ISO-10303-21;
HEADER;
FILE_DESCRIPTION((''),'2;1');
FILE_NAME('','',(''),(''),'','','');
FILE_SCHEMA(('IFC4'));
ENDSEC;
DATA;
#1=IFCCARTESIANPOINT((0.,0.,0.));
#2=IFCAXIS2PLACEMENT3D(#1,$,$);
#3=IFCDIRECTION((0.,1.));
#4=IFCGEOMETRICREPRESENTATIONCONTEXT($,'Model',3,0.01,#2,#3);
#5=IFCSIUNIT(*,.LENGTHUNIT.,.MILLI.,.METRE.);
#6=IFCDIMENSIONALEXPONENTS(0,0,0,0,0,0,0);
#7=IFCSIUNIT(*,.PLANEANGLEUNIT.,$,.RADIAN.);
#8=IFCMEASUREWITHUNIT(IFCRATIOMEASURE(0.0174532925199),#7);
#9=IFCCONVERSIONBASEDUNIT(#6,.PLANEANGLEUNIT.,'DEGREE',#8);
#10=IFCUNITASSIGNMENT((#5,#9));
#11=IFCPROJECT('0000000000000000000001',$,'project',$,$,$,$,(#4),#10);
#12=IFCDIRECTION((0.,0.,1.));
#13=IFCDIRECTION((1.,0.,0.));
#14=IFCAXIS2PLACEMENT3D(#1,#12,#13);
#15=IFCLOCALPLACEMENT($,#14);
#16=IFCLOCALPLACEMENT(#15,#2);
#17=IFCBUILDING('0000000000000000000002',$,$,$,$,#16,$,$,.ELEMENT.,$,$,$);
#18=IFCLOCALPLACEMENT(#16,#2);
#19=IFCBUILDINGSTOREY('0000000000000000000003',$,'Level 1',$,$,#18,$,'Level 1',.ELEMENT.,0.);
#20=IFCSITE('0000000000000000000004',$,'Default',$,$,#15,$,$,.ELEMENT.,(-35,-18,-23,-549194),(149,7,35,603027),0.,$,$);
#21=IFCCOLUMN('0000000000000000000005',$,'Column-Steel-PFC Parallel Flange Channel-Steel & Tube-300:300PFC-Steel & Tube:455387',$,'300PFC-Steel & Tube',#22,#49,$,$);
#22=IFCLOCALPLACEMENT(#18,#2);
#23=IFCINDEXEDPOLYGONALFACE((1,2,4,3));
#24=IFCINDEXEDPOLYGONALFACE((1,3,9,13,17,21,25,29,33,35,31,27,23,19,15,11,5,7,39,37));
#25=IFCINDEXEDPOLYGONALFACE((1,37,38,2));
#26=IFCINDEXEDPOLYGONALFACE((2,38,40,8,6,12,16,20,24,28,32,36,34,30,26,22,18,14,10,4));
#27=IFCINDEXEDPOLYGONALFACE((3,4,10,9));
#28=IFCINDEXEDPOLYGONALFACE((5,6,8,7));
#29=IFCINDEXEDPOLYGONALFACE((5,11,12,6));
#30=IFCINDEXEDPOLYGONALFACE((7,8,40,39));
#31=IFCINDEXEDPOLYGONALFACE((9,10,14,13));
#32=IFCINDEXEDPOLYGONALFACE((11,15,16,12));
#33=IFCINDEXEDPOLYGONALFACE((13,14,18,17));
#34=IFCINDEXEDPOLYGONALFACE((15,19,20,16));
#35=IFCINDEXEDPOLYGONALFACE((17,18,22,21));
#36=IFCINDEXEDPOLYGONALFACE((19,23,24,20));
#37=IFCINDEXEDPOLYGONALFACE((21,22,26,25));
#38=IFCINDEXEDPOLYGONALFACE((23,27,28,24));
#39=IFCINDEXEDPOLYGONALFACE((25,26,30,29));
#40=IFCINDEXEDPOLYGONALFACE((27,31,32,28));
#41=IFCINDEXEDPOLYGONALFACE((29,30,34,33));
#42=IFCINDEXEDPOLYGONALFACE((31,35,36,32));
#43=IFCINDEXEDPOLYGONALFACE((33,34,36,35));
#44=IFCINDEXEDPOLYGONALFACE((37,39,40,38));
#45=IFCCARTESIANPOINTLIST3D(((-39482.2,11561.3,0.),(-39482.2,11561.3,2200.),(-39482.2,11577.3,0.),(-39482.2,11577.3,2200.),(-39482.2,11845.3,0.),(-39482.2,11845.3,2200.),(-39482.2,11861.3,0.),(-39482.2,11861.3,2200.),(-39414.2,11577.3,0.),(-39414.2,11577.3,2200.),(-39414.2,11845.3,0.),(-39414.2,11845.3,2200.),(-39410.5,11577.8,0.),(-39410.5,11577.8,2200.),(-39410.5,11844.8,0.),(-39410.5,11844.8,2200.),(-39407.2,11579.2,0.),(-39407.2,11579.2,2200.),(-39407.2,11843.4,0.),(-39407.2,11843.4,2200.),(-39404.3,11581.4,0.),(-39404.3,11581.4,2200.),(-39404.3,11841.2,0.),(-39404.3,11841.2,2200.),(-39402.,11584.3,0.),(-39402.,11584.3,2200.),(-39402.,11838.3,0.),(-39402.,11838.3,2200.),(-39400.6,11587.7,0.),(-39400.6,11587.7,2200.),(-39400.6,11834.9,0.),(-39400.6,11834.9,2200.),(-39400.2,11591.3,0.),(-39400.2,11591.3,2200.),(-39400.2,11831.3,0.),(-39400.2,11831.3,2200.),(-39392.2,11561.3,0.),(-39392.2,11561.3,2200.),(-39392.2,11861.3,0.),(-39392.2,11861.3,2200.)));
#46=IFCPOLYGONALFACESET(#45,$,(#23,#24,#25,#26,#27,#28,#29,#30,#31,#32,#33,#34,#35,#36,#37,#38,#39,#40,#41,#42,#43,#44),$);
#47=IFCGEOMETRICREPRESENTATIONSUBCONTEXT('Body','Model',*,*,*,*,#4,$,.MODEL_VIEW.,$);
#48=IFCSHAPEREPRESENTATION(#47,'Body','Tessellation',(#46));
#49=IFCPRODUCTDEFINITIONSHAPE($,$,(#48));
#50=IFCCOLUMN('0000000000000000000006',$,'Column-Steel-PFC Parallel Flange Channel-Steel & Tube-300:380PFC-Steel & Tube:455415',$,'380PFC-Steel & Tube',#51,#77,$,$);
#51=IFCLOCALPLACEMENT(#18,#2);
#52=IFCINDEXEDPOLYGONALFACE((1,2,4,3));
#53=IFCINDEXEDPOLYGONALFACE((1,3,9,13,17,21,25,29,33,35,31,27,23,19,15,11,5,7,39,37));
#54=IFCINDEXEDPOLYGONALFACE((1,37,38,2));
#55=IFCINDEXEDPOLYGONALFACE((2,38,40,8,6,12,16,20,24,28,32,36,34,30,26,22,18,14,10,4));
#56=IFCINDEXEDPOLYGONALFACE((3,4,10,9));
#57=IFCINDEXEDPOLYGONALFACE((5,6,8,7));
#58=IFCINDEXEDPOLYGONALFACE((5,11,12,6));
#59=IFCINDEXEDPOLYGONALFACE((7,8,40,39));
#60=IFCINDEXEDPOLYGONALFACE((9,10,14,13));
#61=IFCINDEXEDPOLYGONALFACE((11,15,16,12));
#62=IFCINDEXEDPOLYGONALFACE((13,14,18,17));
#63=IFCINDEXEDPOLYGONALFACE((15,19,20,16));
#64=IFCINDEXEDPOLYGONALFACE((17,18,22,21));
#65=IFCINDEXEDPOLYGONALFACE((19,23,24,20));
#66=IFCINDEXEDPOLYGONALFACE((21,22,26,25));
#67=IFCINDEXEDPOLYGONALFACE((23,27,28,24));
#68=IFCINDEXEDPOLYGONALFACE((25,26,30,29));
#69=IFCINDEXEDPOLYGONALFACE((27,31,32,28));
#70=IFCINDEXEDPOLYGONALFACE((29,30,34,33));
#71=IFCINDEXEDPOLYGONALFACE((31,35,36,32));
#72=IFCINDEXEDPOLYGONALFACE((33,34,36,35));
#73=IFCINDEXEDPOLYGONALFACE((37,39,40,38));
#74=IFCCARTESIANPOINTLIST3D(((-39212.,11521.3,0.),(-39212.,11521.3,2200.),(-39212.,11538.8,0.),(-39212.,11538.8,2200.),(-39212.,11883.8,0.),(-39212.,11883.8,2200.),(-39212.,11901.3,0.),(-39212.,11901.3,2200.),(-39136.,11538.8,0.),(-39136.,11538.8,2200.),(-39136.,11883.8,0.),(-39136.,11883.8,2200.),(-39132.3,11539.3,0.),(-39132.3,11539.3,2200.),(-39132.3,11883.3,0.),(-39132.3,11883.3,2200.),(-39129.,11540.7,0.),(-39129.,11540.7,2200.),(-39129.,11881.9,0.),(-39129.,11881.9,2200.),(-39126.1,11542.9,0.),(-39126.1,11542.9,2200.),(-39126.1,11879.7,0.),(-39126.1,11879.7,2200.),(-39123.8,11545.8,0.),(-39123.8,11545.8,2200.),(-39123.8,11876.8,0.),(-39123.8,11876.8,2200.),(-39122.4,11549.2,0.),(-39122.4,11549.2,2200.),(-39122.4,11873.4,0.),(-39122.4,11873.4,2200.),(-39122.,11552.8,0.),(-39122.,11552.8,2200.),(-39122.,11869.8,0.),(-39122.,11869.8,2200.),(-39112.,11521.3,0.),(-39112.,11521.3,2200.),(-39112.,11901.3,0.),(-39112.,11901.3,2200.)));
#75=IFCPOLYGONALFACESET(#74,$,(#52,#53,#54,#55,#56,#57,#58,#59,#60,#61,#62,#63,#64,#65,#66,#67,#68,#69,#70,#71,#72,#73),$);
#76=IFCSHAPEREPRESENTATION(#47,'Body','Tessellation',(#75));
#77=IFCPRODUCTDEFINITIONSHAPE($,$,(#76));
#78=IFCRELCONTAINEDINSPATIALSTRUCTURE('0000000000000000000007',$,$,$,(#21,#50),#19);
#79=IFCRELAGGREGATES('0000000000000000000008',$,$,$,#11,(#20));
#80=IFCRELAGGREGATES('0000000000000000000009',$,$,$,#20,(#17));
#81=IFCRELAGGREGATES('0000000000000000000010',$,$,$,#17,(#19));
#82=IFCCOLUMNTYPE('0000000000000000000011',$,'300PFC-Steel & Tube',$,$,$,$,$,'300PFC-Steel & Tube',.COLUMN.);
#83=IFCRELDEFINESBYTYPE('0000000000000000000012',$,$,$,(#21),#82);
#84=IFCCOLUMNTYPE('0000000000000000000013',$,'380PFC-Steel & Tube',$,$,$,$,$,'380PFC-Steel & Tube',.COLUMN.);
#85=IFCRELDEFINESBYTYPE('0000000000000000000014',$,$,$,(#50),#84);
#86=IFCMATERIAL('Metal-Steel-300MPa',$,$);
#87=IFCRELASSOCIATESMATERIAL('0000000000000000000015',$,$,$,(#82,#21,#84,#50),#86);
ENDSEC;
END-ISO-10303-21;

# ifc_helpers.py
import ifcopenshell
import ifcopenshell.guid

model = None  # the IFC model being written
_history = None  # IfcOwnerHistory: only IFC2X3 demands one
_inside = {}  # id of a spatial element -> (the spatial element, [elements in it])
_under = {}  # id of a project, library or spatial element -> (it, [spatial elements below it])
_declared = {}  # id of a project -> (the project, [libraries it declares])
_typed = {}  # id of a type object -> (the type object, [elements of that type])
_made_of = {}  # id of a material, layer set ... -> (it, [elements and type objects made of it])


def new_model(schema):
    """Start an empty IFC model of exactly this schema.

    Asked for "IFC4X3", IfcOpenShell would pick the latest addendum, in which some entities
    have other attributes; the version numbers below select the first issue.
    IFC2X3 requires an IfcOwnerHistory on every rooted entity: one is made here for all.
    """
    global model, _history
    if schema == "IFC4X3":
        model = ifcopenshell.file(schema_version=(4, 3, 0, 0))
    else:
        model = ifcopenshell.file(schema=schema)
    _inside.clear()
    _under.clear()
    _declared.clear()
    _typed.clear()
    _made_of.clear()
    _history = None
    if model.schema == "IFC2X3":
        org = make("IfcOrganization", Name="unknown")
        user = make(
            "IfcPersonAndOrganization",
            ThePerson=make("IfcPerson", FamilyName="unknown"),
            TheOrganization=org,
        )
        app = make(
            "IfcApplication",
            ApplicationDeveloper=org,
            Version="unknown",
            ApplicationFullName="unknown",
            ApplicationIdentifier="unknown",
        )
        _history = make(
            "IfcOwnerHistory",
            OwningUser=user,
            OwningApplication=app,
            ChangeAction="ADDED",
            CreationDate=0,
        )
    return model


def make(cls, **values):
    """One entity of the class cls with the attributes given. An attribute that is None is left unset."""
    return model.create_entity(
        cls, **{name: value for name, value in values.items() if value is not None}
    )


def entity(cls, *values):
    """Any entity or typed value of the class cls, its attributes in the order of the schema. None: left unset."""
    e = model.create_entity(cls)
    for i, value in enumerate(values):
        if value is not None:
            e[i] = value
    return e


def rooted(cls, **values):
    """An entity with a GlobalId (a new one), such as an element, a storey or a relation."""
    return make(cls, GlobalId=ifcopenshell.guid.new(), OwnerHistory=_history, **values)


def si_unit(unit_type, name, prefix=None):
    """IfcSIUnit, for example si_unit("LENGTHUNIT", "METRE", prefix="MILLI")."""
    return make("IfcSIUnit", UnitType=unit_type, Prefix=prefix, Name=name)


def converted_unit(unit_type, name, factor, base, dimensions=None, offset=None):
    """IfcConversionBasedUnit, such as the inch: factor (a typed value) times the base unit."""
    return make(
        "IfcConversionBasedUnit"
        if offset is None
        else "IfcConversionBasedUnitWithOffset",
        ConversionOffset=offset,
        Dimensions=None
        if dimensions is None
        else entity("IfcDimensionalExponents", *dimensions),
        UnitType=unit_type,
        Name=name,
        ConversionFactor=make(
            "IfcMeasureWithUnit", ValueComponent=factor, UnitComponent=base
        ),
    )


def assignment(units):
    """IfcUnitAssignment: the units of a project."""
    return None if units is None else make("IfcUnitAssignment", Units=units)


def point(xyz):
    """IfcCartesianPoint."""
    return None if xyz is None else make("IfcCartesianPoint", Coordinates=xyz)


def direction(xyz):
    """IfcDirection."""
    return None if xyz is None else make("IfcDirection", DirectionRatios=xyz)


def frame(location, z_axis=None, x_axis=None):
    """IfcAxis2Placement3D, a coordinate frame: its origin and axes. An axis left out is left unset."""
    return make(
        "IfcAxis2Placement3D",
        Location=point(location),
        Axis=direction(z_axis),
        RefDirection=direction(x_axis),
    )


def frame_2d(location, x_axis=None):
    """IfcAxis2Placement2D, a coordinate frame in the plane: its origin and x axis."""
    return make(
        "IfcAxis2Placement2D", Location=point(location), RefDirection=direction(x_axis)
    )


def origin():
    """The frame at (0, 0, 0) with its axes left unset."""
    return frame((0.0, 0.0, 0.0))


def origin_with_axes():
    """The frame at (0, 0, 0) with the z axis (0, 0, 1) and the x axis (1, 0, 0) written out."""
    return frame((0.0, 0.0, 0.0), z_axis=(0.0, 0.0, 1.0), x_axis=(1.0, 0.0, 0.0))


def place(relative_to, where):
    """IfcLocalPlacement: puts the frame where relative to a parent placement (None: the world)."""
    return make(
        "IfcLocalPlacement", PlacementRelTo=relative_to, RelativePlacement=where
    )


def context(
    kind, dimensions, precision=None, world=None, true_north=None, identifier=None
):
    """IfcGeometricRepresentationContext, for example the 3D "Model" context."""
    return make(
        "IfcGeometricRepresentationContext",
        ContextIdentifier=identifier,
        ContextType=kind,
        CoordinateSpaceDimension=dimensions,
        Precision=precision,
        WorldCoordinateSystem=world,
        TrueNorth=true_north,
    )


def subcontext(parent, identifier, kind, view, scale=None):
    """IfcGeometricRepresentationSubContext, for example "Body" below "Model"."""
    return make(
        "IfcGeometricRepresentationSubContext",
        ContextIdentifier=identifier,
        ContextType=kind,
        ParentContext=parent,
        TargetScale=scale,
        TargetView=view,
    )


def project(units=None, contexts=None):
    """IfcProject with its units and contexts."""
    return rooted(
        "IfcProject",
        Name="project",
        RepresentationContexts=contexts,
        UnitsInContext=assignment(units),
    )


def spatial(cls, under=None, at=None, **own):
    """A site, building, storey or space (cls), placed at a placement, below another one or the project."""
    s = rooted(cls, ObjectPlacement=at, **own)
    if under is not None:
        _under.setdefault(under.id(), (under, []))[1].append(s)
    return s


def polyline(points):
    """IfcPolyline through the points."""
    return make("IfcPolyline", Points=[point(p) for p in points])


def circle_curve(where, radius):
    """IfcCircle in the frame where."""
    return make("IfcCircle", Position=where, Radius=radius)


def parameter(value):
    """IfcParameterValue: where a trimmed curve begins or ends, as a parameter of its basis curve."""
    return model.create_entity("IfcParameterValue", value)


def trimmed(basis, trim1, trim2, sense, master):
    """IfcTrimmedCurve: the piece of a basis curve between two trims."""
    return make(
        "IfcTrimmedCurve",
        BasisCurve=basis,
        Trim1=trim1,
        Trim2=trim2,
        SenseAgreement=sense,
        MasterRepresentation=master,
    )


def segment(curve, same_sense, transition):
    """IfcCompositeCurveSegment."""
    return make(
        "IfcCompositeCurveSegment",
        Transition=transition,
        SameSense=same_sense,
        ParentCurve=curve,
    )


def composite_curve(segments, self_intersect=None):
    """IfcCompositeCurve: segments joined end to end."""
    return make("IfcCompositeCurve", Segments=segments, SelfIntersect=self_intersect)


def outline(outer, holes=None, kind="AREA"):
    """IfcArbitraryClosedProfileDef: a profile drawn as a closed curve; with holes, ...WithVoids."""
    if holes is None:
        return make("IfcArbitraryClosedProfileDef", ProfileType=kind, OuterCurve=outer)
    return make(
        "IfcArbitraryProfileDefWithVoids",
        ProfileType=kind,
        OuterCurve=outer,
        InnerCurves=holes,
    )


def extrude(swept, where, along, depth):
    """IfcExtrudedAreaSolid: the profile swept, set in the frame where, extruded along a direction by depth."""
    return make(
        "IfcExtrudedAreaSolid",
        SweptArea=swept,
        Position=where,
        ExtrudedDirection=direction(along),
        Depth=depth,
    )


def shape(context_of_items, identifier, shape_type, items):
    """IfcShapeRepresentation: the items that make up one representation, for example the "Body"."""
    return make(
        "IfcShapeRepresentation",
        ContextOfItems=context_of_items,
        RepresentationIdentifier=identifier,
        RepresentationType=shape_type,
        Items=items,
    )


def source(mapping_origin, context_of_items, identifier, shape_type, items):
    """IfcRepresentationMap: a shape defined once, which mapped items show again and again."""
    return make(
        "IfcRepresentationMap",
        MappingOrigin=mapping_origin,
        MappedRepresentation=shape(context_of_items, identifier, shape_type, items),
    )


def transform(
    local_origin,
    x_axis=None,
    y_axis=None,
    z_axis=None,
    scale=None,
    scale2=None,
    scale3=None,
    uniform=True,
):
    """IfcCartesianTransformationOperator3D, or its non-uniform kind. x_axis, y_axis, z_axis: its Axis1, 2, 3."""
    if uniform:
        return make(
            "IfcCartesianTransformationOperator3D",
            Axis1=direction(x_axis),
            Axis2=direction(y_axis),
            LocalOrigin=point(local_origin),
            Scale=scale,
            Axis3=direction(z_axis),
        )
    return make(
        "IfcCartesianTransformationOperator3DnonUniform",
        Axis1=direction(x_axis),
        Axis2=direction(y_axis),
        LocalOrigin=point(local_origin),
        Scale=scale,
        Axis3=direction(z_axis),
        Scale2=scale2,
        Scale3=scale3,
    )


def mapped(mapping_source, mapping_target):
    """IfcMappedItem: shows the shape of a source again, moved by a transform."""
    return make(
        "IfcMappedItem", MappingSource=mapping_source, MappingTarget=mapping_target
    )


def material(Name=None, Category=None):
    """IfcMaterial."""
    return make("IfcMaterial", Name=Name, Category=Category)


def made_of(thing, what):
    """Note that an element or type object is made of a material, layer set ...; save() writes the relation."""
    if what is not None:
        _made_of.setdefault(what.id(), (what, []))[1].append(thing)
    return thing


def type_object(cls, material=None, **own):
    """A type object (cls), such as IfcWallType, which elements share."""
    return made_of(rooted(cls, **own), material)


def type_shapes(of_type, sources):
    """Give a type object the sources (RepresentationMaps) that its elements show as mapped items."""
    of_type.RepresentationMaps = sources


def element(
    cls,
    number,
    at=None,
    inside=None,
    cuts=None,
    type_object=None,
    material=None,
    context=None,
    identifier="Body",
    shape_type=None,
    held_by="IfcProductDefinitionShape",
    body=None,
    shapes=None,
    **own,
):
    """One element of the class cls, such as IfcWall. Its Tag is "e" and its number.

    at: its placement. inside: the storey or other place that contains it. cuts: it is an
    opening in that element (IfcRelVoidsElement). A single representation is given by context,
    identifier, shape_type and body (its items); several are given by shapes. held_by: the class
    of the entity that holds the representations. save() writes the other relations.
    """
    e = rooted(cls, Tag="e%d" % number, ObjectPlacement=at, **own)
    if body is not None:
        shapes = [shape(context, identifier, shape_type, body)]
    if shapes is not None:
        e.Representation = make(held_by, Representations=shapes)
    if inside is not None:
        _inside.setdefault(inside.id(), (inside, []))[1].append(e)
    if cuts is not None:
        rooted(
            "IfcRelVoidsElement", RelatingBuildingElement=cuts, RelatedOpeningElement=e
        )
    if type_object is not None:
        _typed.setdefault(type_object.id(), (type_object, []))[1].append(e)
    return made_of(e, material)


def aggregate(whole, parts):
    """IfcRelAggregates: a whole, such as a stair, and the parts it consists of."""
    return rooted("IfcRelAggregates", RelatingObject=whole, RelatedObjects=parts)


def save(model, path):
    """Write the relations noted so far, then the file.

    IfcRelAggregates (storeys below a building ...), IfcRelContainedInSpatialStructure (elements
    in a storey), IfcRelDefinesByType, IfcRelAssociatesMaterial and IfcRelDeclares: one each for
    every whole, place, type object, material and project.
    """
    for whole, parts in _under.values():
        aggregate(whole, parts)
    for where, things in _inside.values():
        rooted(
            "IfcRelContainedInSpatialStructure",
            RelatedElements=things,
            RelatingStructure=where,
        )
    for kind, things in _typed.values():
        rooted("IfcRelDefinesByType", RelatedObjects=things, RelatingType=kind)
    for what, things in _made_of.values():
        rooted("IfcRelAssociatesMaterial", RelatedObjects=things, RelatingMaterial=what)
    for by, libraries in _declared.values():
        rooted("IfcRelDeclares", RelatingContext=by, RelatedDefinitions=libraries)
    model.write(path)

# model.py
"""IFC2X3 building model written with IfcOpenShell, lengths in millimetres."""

from ifc_helpers import new_model, entity, si_unit, converted_unit, direction, frame, frame_2d, origin, origin_with_axes, place, context, subcontext, project, spatial, polyline, circle_curve, parameter, trimmed, segment, composite_curve, outline, extrude, source, transform, mapped, material, type_object, type_shapes, element, save


model = new_model("IFC2X3")

# Units and contexts
model_context = context("Model", 3, precision=0.01, world=origin(), true_north=direction((0.0, 1.0)))
body_context = subcontext(model_context, "Body", "Model", "MODEL_VIEW")
ifc_project = project(units=[si_unit("LENGTHUNIT", "METRE", prefix="MILLI"), converted_unit("PLANEANGLEUNIT", "DEGREE", entity("IfcRatioMeasure", 0.0174532925199), si_unit("PLANEANGLEUNIT", "RADIAN"), dimensions=[0, 0, 0, 0, 0, 0, 0])], contexts=[model_context])

# Site, building, storey
site_placement = place(None, origin_with_axes())
site = spatial("IfcSite", under=ifc_project, at=site_placement, Name="Default", CompositionType="ELEMENT", RefLatitude=(-35, -18, -23, -549194), RefLongitude=(149, 7, 35, 603027), RefElevation=0.0)
building_placement = place(site_placement, origin())
building = spatial("IfcBuilding", under=site, at=building_placement, CompositionType="ELEMENT")
storey_placement = place(building_placement, origin())
storey = spatial("IfcBuildingStorey", under=building, at=storey_placement, Name="Level 1", LongName="Level 1", CompositionType="ELEMENT", Elevation=0.0)

# Columns
ifc_material = material(Name="Metal-Steel-300MPa")
column_type_1 = type_object("IfcColumnType", Name="300PFC-Steel & Tube", ElementType="300PFC-Steel & Tube", PredefinedType="COLUMN", material=ifc_material)
shared_shape_1 = source(origin(), body_context, "Body", "SweptSolid", [
    extrude(outline(composite_curve([segment(polyline([(134.0, -48.0), (150.0, -48.0)]), True, "CONTINUOUS"), segment(polyline([(150.0, -48.0), (150.0, 42.0)]), True, "CONTINUOUS"), segment(polyline([(150.0, 42.0), (-150.0, 42.0)]), True, "CONTINUOUS"), segment(polyline([(-150.0, 42.0), (-150.0, -48.0)]), True, "CONTINUOUS"), segment(polyline([(-150.0, -48.0), (-134.0, -48.0)]), True, "CONTINUOUS"), segment(polyline([(-134.0, -48.0), (-134.0, 20.0)]), True, "CONTINUOUS"), segment(trimmed(circle_curve(frame_2d((-120.0, 20.0), x_axis=(-1.0, 0.0)), 14.0), [parameter(270.0)], [parameter(0.0)], True, "PARAMETER"), False, "CONTINUOUS"), segment(polyline([(-120.0, 34.0), (120.0, 34.0)]), True, "CONTINUOUS"), segment(trimmed(circle_curve(frame_2d((120.0, 20.0), x_axis=(0.0, 1.0)), 14.0), [parameter(270.0)], [parameter(0.0)], True, "PARAMETER"), False, "CONTINUOUS"), segment(polyline([(134.0, 20.0), (134.0, -48.0)]), True, "CONTINUOUS")], self_intersect=False)), frame((3.0, 0.0, 0.0), z_axis=(0.0, 0.0, 1.0), x_axis=(0.0, -1.0, 0.0)), (0.0, 0.0, 1.0), 2200.0),
])
type_shapes(column_type_1, [shared_shape_1])
column_1_placement = place(storey_placement, frame((-39437.2, 11711.3, 0.0)))
element("IfcColumn", 1, at=column_1_placement, inside=storey, type_object=column_type_1, material=ifc_material, Name="Column-Steel-PFC Parallel Flange Channel-Steel & Tube-300:300PFC-Steel & Tube:455387", ObjectType="300PFC-Steel & Tube", context=body_context, shape_type="MappedRepresentation", body=[
    mapped(shared_shape_1, transform((0.0, 0.0, 0.0), scale=1.0)),
])
column_type_2 = type_object("IfcColumnType", Name="380PFC-Steel & Tube", ElementType="380PFC-Steel & Tube", PredefinedType="COLUMN", material=ifc_material)
shared_shape_2 = source(origin(), body_context, "Body", "SweptSolid", [
    extrude(outline(composite_curve([segment(polyline([(172.5, -53.2), (190.0, -53.2)]), True, "CONTINUOUS"), segment(polyline([(190.0, -53.2), (190.0, 46.8)]), True, "CONTINUOUS"), segment(polyline([(190.0, 46.8), (-190.0, 46.8)]), True, "CONTINUOUS"), segment(polyline([(-190.0, 46.8), (-190.0, -53.2)]), True, "CONTINUOUS"), segment(polyline([(-190.0, -53.2), (-172.5, -53.2)]), True, "CONTINUOUS"), segment(polyline([(-172.5, -53.2), (-172.5, 22.8)]), True, "CONTINUOUS"), segment(trimmed(circle_curve(frame_2d((-158.5, 22.8), x_axis=(-1.0, 0.0)), 14.0), [parameter(270.0)], [parameter(0.0)], True, "PARAMETER"), False, "CONTINUOUS"), segment(polyline([(-158.5, 36.8), (158.5, 36.8)]), True, "CONTINUOUS"), segment(trimmed(circle_curve(frame_2d((158.5, 22.8), x_axis=(0.0, 1.0)), 14.0), [parameter(270.0)], [parameter(0.0)], True, "PARAMETER"), False, "CONTINUOUS"), segment(polyline([(172.5, 22.8), (172.5, -53.2)]), True, "CONTINUOUS")], self_intersect=False)), frame((3.2, 0.0, 0.0), z_axis=(0.0, 0.0, 1.0), x_axis=(0.0, -1.0, 0.0)), (0.0, 0.0, 1.0), 2200.0),
])
type_shapes(column_type_2, [shared_shape_2])
column_2_placement = place(storey_placement, frame((-39162.0, 11711.3, 0.0)))
element("IfcColumn", 2, at=column_2_placement, inside=storey, type_object=column_type_2, material=ifc_material, Name="Column-Steel-PFC Parallel Flange Channel-Steel & Tube-300:380PFC-Steel & Tube:455415", ObjectType="380PFC-Steel & Tube", context=body_context, shape_type="MappedRepresentation", body=[
    mapped(shared_shape_2, transform((0.0, 0.0, 0.0), scale=1.0)),
])

save(model, "model.ifc")
